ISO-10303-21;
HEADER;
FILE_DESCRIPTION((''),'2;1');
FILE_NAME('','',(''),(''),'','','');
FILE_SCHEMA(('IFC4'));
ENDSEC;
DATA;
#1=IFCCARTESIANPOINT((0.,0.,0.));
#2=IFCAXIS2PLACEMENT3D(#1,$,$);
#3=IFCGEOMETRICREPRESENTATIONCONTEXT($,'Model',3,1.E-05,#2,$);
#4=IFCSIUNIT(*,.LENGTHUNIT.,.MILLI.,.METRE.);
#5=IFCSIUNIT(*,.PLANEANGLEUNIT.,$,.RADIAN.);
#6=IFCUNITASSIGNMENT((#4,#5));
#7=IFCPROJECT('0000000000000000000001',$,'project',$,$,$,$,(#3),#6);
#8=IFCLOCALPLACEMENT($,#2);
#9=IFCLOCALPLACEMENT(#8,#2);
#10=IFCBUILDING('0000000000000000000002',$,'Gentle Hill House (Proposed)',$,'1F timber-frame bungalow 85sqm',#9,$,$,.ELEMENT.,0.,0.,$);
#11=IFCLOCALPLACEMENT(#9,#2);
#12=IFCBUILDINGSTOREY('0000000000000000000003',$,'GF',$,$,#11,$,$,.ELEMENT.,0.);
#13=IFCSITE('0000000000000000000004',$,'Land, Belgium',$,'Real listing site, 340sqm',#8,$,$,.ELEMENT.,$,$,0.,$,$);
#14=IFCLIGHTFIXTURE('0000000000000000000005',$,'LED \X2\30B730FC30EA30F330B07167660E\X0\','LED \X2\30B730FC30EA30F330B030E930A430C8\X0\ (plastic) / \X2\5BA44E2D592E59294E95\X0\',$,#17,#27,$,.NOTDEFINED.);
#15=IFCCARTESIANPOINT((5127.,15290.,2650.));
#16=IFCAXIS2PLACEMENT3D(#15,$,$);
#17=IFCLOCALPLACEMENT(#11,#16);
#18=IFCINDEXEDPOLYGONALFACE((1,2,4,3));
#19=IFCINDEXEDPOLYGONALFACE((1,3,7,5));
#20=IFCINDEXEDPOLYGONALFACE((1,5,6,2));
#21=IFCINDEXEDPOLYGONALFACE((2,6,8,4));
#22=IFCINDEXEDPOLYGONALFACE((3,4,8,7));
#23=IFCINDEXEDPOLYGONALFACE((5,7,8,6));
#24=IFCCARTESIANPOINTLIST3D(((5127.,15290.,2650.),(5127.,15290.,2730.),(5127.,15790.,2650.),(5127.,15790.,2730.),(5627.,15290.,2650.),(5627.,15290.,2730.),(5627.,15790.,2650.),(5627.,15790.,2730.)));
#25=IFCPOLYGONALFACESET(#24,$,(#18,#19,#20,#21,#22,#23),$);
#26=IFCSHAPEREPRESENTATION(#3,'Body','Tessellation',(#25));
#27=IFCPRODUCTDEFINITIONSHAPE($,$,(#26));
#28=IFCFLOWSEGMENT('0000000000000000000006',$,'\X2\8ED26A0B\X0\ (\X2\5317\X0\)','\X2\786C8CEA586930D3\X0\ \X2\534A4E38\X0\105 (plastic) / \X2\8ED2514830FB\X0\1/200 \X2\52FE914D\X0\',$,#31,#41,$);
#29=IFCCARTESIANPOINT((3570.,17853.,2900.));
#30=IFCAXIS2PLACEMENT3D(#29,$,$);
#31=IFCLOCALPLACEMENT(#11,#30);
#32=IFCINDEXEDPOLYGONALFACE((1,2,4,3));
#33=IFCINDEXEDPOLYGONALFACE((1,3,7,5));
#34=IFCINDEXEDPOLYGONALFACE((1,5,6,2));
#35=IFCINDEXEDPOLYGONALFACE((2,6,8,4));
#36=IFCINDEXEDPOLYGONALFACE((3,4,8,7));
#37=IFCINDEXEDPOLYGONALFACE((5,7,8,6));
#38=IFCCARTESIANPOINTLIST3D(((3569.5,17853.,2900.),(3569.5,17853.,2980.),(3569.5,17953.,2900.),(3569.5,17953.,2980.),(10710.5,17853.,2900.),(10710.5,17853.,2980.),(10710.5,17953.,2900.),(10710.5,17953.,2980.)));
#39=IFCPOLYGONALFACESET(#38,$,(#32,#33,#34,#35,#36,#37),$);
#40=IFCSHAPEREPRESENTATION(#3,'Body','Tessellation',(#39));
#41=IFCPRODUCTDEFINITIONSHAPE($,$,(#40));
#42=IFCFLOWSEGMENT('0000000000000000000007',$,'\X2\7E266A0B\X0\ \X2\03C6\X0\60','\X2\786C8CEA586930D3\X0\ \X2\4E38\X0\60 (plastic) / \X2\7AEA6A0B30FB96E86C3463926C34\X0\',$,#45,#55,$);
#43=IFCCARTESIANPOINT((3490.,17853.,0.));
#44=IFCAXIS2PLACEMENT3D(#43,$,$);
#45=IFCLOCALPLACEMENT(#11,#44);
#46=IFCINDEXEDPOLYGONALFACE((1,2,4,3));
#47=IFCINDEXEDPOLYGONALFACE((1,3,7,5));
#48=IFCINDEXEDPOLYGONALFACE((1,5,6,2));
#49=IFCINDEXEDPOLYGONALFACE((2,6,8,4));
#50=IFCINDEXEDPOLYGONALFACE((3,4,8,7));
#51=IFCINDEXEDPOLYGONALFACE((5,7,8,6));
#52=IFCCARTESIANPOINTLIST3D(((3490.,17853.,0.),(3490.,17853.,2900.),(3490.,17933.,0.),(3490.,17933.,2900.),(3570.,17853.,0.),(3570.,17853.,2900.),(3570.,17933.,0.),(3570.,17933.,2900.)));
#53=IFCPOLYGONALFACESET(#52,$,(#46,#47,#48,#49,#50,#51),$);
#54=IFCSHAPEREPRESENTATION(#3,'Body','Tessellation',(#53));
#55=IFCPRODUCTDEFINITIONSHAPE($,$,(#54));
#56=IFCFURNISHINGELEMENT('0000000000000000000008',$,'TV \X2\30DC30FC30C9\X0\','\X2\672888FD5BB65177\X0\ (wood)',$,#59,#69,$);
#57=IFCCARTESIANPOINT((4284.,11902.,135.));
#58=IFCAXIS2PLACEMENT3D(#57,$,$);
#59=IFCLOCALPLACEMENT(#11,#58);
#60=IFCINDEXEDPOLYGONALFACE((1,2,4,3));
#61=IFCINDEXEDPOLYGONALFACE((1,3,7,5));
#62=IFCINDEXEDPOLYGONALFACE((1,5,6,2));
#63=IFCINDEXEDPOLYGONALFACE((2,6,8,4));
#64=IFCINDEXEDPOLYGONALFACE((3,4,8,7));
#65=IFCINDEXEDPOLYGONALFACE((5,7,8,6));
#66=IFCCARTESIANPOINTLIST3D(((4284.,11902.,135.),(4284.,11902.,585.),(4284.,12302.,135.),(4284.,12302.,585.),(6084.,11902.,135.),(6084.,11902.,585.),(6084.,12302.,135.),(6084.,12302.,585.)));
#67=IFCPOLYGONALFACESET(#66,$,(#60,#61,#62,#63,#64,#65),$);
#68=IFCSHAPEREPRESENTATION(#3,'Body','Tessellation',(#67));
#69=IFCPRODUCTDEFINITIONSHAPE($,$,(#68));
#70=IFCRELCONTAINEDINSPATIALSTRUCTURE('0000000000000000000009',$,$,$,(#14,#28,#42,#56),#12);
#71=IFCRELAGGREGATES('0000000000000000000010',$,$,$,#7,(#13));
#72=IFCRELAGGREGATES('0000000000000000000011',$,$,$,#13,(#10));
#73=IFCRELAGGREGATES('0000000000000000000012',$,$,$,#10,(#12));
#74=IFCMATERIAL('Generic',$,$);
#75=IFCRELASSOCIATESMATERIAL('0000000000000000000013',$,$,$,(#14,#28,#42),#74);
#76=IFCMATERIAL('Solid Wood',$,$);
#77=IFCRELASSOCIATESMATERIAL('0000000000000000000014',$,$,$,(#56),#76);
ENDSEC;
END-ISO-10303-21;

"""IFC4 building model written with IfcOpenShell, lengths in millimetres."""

from ifc_helpers import new_model, si_unit, frame, frame_2d, origin, place, context, project, spatial, rectangle, extrude, material, element, save


model = new_model("IFC4")

# Units and contexts
model_context = context("Model", 3, precision=1e-05, world=origin())
ifc_project = project(units=[si_unit("LENGTHUNIT", "METRE", prefix="MILLI"), si_unit("PLANEANGLEUNIT", "RADIAN")], contexts=[model_context])

# Site, building, storey
site_placement = place(None, origin())
site = spatial("IfcSite", under=ifc_project, at=site_placement, Name="Land, Belgium", ObjectType="Real listing site, 340sqm", CompositionType="ELEMENT", RefElevation=0.0)
building_placement = place(site_placement, origin())
building = spatial("IfcBuilding", under=site, at=building_placement, Name="Gentle Hill House (Proposed)", ObjectType="1F timber-frame bungalow 85sqm", CompositionType="ELEMENT", ElevationOfRefHeight=0.0, ElevationOfTerrain=0.0)
storey_placement = place(building_placement, origin())
storey = spatial("IfcBuildingStorey", under=building, at=storey_placement, Name="GF", CompositionType="ELEMENT", Elevation=0.0)

# Shared definitions
ifc_material_1 = material(Name="Solid Wood")

# Shared definitions
ifc_material_2 = material(Name="Generic")

# Light fixture
light_fixture_placement = place(storey_placement, frame((5127.0, 15290.0, 2650.0)))
element("IfcLightFixture", 1, at=light_fixture_placement, inside=storey, material=ifc_material_2, Name="LED シーリング照明", Description="LED シーリングライト (plastic) / 室中央天井", PredefinedType="NOTDEFINED", context=model_context, shape_type="SweptSolid", body=[
    extrude(rectangle(XDim=500.0, YDim=500.0, at=frame_2d((250.0, 250.0))), frame((5127.0, 15290.0, 2650.0)), (0.0, 0.0, 1.0), 80.0),
])

# Flow segments
flow_segment_1_placement = place(storey_placement, frame((3570.0, 17853.0, 2900.0)))
element("IfcFlowSegment", 2, at=flow_segment_1_placement, inside=storey, material=ifc_material_2, Name="軒樋 (北)", Description="硬質塩ビ 半丸105 (plastic) / 軒先・1/200 勾配", context=model_context, shape_type="SweptSolid", body=[
    extrude(rectangle(XDim=7141.0, YDim=100.0, at=frame_2d((3570.0, 50.0))), frame((3570.0, 17853.0, 2900.0)), (0.0, 0.0, 1.0), 80.0),
])
flow_segment_2_placement = place(storey_placement, frame((3490.0, 17853.0, 0.0)))
element("IfcFlowSegment", 3, at=flow_segment_2_placement, inside=storey, material=ifc_material_2, Name="縦樋 φ60", Description="硬質塩ビ 丸60 (plastic) / 竪樋・雨水排水", context=model_context, shape_type="SweptSolid", body=[
    extrude(rectangle(XDim=80.0, YDim=80.0, at=frame_2d((40.0, 40.0))), frame((3490.0, 17853.0, 0.0)), (0.0, 0.0, 1.0), 2900.0),
])

# Furnishing element
furnishing_placement = place(storey_placement, frame((4284.0, 11902.0, 135.0)))
element("IfcFurnishingElement", 4, at=furnishing_placement, inside=storey, material=ifc_material_1, Name="TV ボード", Description="木製家具 (wood)", context=model_context, shape_type="SweptSolid", body=[
    extrude(rectangle(XDim=1800.0, YDim=400.0, at=frame_2d((900.0, 200.0))), frame((4284.0, 11902.0, 135.0)), (0.0, 0.0, 1.0), 450.0),
])

save(model, "model.ifc")
